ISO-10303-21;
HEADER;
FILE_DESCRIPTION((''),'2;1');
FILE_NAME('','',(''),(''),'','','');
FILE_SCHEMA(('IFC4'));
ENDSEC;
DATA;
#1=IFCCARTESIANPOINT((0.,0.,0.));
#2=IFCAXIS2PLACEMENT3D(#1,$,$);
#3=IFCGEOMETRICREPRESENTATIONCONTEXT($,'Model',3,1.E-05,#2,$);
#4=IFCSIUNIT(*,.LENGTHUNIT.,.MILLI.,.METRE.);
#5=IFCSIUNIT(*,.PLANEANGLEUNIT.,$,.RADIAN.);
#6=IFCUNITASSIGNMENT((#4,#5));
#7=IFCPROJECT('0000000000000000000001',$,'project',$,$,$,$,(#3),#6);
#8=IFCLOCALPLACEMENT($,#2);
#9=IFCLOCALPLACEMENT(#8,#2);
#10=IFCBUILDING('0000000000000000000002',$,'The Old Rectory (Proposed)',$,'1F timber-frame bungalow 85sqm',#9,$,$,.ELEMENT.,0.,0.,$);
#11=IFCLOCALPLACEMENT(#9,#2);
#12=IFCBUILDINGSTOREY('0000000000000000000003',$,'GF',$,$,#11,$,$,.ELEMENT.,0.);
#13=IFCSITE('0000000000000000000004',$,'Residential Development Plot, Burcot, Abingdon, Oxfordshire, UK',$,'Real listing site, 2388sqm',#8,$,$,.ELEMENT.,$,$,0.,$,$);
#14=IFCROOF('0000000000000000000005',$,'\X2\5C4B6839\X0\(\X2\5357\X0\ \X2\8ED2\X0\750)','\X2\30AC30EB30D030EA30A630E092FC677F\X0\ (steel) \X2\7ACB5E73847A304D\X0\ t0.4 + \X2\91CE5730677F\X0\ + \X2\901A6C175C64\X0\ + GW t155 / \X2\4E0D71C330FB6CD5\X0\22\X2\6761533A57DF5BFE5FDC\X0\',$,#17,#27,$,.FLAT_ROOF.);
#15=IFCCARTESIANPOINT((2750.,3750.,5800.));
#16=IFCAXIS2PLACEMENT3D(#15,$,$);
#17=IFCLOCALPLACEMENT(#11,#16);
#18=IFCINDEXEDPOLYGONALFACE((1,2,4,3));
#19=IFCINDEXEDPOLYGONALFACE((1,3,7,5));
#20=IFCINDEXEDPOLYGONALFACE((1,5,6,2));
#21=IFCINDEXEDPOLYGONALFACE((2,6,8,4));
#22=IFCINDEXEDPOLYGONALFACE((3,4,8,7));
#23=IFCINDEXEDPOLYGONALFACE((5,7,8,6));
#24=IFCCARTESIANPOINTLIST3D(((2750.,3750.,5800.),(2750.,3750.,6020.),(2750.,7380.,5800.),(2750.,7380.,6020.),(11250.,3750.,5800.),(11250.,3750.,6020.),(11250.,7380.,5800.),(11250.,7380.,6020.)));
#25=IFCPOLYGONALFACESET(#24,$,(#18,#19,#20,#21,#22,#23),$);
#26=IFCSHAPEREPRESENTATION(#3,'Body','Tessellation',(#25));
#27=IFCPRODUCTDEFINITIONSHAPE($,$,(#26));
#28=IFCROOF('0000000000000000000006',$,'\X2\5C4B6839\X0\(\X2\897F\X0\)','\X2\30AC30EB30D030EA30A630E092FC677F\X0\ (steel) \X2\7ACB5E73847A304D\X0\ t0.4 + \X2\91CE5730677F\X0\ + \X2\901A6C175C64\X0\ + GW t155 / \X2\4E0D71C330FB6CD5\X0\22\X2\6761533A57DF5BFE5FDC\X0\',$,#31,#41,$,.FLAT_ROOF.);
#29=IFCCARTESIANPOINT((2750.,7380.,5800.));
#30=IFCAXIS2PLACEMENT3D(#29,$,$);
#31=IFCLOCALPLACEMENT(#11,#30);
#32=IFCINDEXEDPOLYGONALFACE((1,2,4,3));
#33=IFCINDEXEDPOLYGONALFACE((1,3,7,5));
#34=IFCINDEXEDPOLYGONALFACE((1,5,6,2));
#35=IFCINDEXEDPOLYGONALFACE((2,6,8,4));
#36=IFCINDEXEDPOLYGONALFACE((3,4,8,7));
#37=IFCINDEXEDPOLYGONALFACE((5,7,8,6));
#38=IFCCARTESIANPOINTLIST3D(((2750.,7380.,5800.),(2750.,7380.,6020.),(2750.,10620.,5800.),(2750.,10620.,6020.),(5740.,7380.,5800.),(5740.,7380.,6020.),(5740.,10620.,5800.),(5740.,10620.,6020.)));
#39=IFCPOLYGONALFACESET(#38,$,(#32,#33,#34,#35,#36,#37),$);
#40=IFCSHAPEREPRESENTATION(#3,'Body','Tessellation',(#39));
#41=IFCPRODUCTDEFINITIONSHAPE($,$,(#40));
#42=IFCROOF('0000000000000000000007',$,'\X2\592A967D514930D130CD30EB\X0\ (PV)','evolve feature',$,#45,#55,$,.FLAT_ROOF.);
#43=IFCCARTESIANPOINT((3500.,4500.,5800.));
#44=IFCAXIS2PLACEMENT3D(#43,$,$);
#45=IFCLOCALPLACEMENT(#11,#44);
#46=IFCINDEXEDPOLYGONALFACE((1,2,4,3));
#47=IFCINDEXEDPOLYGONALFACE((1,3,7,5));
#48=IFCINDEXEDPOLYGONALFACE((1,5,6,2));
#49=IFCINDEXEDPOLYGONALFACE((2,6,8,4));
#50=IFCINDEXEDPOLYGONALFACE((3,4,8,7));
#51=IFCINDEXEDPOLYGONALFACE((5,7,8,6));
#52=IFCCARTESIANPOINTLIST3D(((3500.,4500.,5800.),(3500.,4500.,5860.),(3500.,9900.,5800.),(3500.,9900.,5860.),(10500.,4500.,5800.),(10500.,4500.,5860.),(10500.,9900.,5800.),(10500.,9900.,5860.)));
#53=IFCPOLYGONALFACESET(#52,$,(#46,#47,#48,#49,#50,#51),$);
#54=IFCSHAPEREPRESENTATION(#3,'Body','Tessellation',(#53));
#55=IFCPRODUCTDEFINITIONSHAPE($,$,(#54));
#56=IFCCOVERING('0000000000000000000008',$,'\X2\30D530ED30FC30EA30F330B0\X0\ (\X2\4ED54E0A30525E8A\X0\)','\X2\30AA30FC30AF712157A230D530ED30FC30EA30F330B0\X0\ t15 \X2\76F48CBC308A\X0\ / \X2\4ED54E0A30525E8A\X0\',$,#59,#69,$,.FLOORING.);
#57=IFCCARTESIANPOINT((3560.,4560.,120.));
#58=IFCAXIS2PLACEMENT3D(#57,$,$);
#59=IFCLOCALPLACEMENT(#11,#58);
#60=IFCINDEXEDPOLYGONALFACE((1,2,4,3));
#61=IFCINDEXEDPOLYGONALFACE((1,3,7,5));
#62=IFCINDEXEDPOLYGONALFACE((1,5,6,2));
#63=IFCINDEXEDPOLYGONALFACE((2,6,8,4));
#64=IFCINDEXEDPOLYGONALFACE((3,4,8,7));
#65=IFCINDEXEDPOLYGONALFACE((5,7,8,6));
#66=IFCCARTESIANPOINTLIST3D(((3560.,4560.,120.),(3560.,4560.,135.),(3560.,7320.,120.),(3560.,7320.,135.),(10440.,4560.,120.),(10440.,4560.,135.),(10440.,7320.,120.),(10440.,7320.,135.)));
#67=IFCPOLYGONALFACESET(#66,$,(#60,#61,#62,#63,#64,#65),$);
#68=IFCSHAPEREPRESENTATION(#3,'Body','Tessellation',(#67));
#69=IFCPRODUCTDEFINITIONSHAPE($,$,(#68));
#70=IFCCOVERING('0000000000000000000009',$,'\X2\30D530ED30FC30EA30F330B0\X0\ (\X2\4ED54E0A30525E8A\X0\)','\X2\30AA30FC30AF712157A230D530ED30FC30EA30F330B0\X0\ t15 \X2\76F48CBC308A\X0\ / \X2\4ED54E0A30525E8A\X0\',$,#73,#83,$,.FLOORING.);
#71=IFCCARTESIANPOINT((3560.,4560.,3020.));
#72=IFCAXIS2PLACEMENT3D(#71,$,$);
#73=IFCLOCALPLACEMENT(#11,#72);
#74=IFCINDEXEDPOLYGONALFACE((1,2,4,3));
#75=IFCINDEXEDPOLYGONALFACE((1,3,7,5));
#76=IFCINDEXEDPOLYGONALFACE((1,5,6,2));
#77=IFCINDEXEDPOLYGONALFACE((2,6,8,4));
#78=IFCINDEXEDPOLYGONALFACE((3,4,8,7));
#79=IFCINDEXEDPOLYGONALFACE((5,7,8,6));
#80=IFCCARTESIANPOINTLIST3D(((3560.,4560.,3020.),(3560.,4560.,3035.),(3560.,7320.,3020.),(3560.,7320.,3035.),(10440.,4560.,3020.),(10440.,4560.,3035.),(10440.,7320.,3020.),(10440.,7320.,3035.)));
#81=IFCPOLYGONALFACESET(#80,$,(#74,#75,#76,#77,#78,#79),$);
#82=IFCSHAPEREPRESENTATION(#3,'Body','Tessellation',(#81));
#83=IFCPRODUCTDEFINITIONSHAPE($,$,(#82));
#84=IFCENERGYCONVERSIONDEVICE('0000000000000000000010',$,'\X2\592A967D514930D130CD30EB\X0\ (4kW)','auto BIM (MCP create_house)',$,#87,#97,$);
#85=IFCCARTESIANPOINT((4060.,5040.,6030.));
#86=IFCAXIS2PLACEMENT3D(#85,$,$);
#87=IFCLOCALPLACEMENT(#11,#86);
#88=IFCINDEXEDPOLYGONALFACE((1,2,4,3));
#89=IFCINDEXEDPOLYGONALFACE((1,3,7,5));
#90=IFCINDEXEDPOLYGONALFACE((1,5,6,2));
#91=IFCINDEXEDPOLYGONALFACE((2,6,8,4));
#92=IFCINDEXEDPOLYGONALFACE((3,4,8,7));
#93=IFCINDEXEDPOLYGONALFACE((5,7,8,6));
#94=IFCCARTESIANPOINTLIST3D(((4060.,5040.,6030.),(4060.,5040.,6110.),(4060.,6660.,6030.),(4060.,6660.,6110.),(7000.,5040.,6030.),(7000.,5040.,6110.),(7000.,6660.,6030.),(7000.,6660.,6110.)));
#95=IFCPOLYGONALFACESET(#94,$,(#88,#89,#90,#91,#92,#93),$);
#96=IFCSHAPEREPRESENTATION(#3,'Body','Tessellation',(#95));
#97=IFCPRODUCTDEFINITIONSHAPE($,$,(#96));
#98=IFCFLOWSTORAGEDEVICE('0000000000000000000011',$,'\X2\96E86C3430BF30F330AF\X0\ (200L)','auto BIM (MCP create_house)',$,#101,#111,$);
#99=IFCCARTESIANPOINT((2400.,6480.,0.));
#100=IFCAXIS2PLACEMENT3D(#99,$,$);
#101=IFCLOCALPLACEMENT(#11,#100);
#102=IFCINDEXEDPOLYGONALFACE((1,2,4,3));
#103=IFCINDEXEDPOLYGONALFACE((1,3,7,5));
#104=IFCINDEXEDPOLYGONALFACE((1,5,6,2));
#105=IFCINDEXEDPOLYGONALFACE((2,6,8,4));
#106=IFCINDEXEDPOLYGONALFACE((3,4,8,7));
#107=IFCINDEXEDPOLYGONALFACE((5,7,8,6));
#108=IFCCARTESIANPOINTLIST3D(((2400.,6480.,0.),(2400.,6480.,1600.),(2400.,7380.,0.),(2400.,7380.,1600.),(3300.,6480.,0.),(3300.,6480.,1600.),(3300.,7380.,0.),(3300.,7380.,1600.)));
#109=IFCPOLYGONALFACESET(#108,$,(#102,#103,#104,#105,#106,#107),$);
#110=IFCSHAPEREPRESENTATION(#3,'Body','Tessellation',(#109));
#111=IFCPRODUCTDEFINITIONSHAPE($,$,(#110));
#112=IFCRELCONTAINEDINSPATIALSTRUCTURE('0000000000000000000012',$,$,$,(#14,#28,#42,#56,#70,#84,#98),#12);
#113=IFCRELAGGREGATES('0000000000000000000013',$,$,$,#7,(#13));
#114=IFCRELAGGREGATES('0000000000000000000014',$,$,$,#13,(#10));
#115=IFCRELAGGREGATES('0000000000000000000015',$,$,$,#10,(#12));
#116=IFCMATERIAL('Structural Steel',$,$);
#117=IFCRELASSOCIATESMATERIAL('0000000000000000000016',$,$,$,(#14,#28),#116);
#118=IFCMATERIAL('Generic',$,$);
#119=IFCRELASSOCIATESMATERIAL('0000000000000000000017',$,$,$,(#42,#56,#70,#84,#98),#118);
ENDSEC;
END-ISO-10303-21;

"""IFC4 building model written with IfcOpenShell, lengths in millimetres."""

from ifc_helpers import new_model, si_unit, frame, frame_2d, origin, place, context, project, spatial, rectangle, extrude, material, element, save


model = new_model("IFC4")

# Units and contexts
model_context = context("Model", 3, precision=1e-05, world=origin())
ifc_project = project(units=[si_unit("LENGTHUNIT", "METRE", prefix="MILLI"), si_unit("PLANEANGLEUNIT", "RADIAN")], contexts=[model_context])

# Site, building, storey
site_placement = place(None, origin())
site = spatial("IfcSite", under=ifc_project, at=site_placement, Name="Residential Development Plot, Burcot, Abingdon, Oxfordshire, UK", ObjectType="Real listing site, 2388sqm", CompositionType="ELEMENT", RefElevation=0.0)
building_placement = place(site_placement, origin())
building = spatial("IfcBuilding", under=site, at=building_placement, Name="The Old Rectory (Proposed)", ObjectType="1F timber-frame bungalow 85sqm", CompositionType="ELEMENT", ElevationOfRefHeight=0.0, ElevationOfTerrain=0.0)
storey_placement = place(building_placement, origin())
storey = spatial("IfcBuildingStorey", under=building, at=storey_placement, Name="GF", CompositionType="ELEMENT", Elevation=0.0)

# Shared definitions
ifc_material_1 = material(Name="Generic")

# Roofs
ifc_material_2 = material(Name="Structural Steel")
roof_1_placement = place(storey_placement, frame((2750.0, 3750.0, 5800.0)))
element("IfcRoof", 1, at=roof_1_placement, inside=storey, material=ifc_material_2, Name="屋根(南 軒750)", Description="ガルバリウム鋼板 (steel) 立平葺き t0.4 + 野地板 + 通気層 + GW t155 / 不燃・法22条区域対応", PredefinedType="FLAT_ROOF", context=model_context, shape_type="SweptSolid", body=[
    extrude(rectangle(XDim=8500.0, YDim=3630.0, at=frame_2d((4250.0, 1815.0))), frame((2750.0, 3750.0, 5800.0)), (0.0, 0.0, 1.0), 220.0),
])
roof_2_placement = place(storey_placement, frame((2750.0, 7380.0, 5800.0)))
element("IfcRoof", 2, at=roof_2_placement, inside=storey, material=ifc_material_2, Name="屋根(西)", Description="ガルバリウム鋼板 (steel) 立平葺き t0.4 + 野地板 + 通気層 + GW t155 / 不燃・法22条区域対応", PredefinedType="FLAT_ROOF", context=model_context, shape_type="SweptSolid", body=[
    extrude(rectangle(XDim=2990.0, YDim=3240.0, at=frame_2d((1495.0, 1620.0))), frame((2750.0, 7380.0, 5800.0)), (0.0, 0.0, 1.0), 220.0),
])
roof_3_placement = place(storey_placement, frame((3500.0, 4500.0, 5800.0)))
element("IfcRoof", 3, at=roof_3_placement, inside=storey, material=ifc_material_1, Name="太陽光パネル (PV)", Description="evolve feature", PredefinedType="FLAT_ROOF", context=model_context, shape_type="SweptSolid", body=[
    extrude(rectangle(XDim=7000.0, YDim=5400.0, at=frame_2d((3500.0, 2700.0))), frame((3500.0, 4500.0, 5800.0)), (0.0, 0.0, 1.0), 60.0),
])

# Coverings
covering_1_placement = place(storey_placement, frame((3560.0, 4560.0, 120.0)))
element("IfcCovering", 4, at=covering_1_placement, inside=storey, material=ifc_material_1, Name="フローリング (仕上げ床)", Description="オーク無垢フローリング t15 直貼り / 仕上げ床", PredefinedType="FLOORING", context=model_context, shape_type="SweptSolid", body=[
    extrude(rectangle(XDim=6880.0, YDim=2760.0, at=frame_2d((3440.0, 1380.0))), frame((3560.0, 4560.0, 120.0)), (0.0, 0.0, 1.0), 15.0),
])
covering_2_placement = place(storey_placement, frame((3560.0, 4560.0, 3020.0)))
element("IfcCovering", 5, at=covering_2_placement, inside=storey, material=ifc_material_1, Name="フローリング (仕上げ床)", Description="オーク無垢フローリング t15 直貼り / 仕上げ床", PredefinedType="FLOORING", context=model_context, shape_type="SweptSolid", body=[
    extrude(rectangle(XDim=6880.0, YDim=2760.0, at=frame_2d((3440.0, 1380.0))), frame((3560.0, 4560.0, 3020.0)), (0.0, 0.0, 1.0), 15.0),
])

# Energy conversion device
energy_conversion_device_placement = place(storey_placement, frame((4060.0, 5040.0, 6030.0)))
element("IfcEnergyConversionDevice", 6, at=energy_conversion_device_placement, inside=storey, material=ifc_material_1, Name="太陽光パネル (4kW)", Description="auto BIM (MCP create_house)", context=model_context, shape_type="SweptSolid", body=[
    extrude(rectangle(XDim=2940.0, YDim=1620.0, at=frame_2d((1470.0, 810.0))), frame((4060.0, 5040.0, 6030.0)), (0.0, 0.0, 1.0), 80.0),
])

# Flow storage device
flow_storage_device_placement = place(storey_placement, frame((2400.0, 6480.0, 0.0)))
element("IfcFlowStorageDevice", 7, at=flow_storage_device_placement, inside=storey, material=ifc_material_1, Name="雨水タンク (200L)", Description="auto BIM (MCP create_house)", context=model_context, shape_type="SweptSolid", body=[
    extrude(rectangle(XDim=900.0, YDim=900.0, at=frame_2d((450.0, 450.0))), frame((2400.0, 6480.0, 0.0)), (0.0, 0.0, 1.0), 1600.0),
])

save(model, "model.ifc")
